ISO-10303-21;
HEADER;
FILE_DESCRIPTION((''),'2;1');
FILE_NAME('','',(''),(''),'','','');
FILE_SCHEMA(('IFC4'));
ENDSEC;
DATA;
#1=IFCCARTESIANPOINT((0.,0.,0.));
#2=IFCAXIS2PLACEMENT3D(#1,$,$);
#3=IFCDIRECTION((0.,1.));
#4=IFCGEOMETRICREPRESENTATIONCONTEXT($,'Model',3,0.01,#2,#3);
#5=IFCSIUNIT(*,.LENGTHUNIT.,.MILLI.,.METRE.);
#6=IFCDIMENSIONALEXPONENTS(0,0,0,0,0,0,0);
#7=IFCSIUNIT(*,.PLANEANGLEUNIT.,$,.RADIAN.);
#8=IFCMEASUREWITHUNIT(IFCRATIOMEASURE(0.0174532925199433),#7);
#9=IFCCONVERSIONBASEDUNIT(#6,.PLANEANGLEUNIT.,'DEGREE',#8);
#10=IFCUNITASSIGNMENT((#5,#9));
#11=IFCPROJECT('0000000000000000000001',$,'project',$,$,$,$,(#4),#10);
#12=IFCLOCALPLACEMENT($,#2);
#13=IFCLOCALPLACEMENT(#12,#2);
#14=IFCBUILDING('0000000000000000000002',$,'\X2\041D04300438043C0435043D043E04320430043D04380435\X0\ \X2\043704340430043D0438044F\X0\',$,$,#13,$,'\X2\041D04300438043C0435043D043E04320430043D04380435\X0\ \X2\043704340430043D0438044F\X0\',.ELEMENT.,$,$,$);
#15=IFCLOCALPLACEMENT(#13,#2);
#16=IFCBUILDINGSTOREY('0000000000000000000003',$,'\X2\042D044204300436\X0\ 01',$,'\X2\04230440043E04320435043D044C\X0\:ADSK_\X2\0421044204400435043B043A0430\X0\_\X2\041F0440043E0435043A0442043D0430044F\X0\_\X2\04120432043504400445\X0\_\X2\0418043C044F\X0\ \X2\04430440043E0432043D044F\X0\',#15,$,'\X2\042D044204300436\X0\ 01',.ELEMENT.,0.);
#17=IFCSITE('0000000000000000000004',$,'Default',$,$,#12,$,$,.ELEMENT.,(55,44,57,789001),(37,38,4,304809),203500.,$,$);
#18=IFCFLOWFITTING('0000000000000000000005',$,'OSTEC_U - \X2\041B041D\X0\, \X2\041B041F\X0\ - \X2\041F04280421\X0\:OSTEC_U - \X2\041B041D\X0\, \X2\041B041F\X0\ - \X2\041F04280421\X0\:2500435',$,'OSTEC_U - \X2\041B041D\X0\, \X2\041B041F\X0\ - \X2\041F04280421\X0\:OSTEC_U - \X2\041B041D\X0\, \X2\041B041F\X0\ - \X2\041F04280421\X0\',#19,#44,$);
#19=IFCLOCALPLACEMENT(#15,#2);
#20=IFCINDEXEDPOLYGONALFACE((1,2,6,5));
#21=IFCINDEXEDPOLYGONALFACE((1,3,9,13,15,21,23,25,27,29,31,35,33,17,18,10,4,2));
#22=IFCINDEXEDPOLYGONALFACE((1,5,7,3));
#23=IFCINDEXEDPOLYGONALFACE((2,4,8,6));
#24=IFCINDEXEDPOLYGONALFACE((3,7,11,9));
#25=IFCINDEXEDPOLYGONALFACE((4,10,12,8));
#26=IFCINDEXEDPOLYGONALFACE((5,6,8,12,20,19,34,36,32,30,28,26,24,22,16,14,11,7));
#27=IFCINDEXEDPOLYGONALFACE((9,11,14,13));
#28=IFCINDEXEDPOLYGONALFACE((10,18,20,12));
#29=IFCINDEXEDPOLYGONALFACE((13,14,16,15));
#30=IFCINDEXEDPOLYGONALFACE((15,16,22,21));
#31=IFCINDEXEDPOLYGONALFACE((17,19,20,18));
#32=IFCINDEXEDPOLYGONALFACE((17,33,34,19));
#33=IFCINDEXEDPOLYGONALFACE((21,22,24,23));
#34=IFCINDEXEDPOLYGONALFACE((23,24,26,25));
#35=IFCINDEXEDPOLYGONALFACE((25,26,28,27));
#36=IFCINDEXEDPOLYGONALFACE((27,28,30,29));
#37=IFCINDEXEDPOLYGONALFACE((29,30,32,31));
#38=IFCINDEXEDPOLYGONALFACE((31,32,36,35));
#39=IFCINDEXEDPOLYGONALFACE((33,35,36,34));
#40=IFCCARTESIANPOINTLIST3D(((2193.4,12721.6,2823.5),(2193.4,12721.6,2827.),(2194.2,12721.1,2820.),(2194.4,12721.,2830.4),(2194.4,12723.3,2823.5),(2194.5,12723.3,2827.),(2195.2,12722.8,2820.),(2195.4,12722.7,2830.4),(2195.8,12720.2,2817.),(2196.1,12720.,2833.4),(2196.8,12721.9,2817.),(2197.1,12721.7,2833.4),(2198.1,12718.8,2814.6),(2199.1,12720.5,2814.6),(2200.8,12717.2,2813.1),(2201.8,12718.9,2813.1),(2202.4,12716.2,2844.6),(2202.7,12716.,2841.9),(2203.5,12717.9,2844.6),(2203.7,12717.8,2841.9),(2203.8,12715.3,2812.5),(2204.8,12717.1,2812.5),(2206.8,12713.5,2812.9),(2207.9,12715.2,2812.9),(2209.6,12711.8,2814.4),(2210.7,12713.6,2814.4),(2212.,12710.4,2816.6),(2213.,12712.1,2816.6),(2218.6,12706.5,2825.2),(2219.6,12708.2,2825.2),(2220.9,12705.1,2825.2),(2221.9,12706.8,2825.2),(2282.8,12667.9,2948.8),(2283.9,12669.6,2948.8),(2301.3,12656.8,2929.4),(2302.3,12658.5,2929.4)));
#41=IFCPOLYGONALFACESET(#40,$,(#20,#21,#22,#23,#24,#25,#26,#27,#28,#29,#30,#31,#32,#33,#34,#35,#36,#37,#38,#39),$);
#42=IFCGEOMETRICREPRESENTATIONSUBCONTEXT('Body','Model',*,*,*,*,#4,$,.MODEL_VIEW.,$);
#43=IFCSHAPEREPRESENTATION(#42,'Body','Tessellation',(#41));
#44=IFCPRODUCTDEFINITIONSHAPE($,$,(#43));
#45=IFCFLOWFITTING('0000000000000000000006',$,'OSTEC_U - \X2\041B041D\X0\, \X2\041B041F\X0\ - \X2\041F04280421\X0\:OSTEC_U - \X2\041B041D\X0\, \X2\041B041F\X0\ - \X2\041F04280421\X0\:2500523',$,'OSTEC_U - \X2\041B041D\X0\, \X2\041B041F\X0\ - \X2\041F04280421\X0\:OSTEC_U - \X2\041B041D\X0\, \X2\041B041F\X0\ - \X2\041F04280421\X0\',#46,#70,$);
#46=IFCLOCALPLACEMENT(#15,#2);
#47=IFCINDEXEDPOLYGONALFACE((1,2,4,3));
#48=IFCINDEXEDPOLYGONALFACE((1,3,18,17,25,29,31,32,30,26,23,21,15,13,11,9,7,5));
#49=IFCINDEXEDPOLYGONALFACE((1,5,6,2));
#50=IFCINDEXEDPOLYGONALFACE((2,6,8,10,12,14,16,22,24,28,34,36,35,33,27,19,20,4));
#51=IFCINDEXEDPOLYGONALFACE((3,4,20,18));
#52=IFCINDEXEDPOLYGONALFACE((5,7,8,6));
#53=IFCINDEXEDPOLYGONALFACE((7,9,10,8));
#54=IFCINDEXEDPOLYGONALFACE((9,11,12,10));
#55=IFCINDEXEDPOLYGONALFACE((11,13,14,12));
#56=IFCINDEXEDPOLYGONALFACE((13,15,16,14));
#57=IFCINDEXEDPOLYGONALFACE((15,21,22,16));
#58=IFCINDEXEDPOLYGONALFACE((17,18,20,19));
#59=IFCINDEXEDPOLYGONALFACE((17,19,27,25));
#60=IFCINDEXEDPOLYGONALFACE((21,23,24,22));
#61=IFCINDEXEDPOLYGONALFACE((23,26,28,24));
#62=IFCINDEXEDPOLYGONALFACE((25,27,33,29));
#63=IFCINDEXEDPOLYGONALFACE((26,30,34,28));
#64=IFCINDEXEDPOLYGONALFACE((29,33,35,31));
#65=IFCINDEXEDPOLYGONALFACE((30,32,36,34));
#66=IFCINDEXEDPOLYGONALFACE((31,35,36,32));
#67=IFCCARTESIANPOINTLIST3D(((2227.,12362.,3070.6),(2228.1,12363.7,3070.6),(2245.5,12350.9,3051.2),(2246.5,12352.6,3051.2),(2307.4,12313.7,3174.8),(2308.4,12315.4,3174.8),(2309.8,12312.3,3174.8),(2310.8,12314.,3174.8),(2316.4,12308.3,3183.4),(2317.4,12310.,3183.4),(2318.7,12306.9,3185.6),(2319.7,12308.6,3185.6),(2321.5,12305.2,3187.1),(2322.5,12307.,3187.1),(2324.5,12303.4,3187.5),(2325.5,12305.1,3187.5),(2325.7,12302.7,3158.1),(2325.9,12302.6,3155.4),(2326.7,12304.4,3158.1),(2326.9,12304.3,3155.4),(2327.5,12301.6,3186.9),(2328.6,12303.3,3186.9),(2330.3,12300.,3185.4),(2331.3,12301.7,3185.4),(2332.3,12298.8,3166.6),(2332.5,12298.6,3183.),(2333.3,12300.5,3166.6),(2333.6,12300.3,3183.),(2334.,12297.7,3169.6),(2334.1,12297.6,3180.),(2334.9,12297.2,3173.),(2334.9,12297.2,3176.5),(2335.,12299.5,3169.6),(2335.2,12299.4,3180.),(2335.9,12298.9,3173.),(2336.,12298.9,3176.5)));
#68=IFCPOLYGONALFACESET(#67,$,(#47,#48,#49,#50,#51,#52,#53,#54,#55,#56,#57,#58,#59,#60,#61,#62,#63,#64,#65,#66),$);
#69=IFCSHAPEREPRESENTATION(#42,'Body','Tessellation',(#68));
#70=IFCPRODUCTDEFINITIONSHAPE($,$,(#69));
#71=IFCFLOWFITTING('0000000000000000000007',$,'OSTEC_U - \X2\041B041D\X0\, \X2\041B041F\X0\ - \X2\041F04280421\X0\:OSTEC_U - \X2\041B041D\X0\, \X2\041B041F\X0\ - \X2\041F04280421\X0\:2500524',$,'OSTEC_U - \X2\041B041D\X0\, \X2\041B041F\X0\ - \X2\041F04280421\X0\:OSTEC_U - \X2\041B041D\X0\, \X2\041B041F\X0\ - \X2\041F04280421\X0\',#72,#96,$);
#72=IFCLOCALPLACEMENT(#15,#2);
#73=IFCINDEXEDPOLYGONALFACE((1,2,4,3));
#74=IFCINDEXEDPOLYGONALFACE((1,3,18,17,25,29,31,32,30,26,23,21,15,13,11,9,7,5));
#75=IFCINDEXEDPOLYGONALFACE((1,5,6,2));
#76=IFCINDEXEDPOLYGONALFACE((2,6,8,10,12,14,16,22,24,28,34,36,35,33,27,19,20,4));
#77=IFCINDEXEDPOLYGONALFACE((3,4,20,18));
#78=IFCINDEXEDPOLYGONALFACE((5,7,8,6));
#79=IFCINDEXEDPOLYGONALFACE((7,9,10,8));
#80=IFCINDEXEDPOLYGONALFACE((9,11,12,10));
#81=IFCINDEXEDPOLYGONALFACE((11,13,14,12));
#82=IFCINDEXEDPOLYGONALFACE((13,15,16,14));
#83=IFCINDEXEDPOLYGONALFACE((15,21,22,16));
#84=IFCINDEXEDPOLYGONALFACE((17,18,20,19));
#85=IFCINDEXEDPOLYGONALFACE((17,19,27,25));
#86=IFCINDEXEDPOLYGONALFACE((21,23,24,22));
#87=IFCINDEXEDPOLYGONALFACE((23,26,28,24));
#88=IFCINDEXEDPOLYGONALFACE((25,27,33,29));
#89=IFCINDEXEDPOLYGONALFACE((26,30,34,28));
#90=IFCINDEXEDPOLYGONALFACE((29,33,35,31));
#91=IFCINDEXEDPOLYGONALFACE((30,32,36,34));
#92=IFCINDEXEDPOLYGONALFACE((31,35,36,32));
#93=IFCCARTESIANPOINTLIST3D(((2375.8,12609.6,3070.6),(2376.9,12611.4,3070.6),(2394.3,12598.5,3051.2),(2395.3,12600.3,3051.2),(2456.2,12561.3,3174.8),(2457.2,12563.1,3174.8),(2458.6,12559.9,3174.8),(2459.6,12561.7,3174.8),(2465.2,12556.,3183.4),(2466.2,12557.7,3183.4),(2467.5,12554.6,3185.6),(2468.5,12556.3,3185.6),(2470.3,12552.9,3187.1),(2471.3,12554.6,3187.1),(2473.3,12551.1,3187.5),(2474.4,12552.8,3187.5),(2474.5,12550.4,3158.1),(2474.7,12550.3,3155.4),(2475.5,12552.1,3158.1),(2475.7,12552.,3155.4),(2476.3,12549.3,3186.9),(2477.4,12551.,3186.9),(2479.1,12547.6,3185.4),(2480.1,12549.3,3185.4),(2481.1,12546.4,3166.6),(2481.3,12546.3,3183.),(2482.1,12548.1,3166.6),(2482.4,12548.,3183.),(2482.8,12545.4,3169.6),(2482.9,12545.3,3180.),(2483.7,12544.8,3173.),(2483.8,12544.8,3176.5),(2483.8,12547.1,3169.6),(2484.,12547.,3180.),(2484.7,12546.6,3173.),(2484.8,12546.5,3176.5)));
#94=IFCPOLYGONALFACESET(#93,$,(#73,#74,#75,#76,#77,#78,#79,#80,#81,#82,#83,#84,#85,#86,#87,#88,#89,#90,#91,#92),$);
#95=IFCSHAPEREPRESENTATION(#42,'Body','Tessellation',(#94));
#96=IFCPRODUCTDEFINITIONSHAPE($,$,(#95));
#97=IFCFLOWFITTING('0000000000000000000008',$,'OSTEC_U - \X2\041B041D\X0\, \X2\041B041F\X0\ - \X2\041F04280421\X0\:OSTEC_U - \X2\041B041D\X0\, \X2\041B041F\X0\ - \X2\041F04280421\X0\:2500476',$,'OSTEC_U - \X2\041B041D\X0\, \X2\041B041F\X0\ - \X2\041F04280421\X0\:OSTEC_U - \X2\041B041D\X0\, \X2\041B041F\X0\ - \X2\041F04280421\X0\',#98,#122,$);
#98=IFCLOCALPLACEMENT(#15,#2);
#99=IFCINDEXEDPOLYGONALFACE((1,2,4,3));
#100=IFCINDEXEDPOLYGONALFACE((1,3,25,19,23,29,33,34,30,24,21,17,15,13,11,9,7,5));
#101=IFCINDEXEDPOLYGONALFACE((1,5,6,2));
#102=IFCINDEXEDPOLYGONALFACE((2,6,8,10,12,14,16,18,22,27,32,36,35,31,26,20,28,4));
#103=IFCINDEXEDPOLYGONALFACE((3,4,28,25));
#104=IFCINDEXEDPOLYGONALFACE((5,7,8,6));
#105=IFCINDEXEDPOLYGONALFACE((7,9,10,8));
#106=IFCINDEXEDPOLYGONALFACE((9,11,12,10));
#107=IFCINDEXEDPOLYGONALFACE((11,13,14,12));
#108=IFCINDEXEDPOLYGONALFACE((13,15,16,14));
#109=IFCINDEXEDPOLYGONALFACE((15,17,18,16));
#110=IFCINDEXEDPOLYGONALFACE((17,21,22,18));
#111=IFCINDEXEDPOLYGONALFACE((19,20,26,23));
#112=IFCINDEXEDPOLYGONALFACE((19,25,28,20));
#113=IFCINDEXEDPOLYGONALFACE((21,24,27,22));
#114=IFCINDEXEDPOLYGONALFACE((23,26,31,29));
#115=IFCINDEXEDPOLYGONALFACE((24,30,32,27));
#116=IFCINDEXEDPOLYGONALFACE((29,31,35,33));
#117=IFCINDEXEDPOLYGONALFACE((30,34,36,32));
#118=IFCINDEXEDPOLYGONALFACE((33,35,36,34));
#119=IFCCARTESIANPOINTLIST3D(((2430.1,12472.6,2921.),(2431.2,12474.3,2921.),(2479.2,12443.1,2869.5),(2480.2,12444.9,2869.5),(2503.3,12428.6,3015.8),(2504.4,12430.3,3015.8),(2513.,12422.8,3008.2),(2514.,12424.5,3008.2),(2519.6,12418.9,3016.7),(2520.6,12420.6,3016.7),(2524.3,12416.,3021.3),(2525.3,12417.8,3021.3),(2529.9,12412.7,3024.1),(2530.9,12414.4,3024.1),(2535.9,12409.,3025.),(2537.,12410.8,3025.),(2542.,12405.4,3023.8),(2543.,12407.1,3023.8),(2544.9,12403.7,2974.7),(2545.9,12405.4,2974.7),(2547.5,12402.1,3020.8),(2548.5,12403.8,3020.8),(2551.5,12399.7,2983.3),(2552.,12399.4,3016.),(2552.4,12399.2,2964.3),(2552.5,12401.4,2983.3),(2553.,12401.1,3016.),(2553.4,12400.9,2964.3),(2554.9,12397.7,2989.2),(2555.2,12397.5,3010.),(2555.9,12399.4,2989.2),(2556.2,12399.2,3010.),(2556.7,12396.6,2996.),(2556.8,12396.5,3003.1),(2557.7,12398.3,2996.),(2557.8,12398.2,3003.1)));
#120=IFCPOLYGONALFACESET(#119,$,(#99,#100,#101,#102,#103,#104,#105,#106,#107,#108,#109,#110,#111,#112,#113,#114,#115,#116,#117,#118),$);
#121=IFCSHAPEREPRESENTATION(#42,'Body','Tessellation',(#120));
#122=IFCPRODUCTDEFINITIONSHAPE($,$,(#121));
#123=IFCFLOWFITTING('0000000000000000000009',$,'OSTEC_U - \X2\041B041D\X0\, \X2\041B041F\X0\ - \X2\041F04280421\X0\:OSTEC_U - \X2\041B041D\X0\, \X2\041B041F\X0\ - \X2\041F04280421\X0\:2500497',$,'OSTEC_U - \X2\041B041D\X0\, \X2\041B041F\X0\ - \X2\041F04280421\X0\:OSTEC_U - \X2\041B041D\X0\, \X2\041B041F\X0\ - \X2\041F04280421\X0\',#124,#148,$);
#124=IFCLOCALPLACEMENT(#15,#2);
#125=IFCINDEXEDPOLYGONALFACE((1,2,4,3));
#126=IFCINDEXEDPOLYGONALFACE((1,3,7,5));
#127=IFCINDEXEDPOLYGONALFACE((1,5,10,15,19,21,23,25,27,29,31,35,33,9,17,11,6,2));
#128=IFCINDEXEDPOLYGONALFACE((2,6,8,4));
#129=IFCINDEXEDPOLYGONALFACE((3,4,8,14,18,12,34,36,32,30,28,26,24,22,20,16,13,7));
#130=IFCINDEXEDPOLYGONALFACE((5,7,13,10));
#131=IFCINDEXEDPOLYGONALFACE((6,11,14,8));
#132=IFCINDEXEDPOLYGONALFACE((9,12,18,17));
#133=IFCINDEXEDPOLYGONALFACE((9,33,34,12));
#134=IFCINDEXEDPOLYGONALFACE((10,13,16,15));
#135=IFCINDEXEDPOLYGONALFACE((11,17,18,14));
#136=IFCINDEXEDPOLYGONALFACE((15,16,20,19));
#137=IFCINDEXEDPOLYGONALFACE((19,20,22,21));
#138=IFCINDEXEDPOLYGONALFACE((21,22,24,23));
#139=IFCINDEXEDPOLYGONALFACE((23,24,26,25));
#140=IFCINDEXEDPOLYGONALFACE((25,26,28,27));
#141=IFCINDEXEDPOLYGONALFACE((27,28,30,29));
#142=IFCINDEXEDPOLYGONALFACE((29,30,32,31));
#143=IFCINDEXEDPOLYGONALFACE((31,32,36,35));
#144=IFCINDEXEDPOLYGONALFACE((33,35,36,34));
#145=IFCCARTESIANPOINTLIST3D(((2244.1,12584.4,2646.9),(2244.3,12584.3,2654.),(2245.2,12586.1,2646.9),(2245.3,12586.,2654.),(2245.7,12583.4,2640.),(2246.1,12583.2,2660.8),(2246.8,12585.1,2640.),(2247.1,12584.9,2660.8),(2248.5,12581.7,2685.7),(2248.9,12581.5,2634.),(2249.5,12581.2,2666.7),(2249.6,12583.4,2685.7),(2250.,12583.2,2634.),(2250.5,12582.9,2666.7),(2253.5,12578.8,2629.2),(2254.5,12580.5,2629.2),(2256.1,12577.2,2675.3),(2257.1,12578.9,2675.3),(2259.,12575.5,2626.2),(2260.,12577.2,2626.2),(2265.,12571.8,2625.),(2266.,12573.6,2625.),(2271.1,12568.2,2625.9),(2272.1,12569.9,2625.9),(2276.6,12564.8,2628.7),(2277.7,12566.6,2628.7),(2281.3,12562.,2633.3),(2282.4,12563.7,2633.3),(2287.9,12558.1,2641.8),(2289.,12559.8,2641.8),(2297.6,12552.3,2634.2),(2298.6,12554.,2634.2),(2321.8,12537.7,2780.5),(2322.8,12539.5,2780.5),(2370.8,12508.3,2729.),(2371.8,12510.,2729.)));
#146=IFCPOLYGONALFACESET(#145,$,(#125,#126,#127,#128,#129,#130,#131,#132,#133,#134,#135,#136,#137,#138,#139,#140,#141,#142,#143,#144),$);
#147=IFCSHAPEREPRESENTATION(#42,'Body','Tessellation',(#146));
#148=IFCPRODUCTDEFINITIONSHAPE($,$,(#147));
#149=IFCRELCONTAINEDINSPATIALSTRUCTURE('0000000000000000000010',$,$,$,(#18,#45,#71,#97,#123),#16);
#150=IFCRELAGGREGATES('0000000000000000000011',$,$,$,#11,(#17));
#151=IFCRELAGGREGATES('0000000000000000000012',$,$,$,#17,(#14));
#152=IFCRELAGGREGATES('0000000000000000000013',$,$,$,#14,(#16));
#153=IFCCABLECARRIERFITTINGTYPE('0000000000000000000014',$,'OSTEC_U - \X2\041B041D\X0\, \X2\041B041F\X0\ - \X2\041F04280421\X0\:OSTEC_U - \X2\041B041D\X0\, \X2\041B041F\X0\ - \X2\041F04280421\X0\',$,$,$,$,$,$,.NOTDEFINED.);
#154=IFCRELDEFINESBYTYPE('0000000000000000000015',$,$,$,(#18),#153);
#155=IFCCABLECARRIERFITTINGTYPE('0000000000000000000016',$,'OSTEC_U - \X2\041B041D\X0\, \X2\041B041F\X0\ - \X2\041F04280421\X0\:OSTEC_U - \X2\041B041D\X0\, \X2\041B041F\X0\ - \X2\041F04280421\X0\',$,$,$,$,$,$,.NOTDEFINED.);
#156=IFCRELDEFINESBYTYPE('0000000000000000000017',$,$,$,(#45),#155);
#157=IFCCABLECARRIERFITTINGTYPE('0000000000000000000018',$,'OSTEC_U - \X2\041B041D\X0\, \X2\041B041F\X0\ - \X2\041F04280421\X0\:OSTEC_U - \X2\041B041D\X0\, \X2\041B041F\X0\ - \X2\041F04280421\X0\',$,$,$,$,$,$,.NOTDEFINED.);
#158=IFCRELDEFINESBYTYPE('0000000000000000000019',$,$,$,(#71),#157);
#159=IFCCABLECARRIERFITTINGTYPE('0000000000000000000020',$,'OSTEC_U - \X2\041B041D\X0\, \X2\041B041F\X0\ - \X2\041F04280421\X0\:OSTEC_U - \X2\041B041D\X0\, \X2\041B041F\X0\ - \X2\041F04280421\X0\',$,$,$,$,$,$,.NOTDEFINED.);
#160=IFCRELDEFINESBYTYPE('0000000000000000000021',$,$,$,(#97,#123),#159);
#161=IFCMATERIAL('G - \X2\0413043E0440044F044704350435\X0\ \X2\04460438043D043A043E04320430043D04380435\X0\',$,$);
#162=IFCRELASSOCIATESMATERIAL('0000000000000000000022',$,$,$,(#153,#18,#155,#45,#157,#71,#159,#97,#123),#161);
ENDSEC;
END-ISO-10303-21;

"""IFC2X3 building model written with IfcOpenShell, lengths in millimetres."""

from ifc_helpers import new_model, entity, si_unit, converted_unit, direction, frame, frame_2d, origin, place, context, subcontext, project, spatial, polyline, circle_curve, parameter, trimmed, segment, composite_curve, outline, extrude, source, transform, mapped, material, type_object, type_shapes, element, save


model = new_model("IFC2X3")

# Units and contexts
model_context = context("Model", 3, precision=0.01, world=origin(), true_north=direction((0.0, 1.0)))
body_context = subcontext(model_context, "Body", "Model", "MODEL_VIEW")
ifc_project = project(units=[si_unit("LENGTHUNIT", "METRE", prefix="MILLI"), converted_unit("PLANEANGLEUNIT", "DEGREE", entity("IfcRatioMeasure", 0.0174532925199433), si_unit("PLANEANGLEUNIT", "RADIAN"), dimensions=[0, 0, 0, 0, 0, 0, 0])], contexts=[model_context])

# Site, building, storey
site_placement = place(None, frame((0.0, 0.0, 0.0)))
site = spatial("IfcSite", under=ifc_project, at=site_placement, Name="Default", CompositionType="ELEMENT", RefLatitude=(55, 44, 57, 789001), RefLongitude=(37, 38, 4, 304809), RefElevation=203500.0)
building_placement = place(site_placement, origin())
building = spatial("IfcBuilding", under=site, at=building_placement, Name="Наименование здания", LongName="Наименование здания", CompositionType="ELEMENT")
storey_placement = place(building_placement, origin())
storey = spatial("IfcBuildingStorey", under=building, at=storey_placement, Name="Этаж 01", ObjectType="Уровень:ADSK_Стрелка_Проектная_Вверх_Имя уровня", LongName="Этаж 01", CompositionType="ELEMENT", Elevation=0.0)

# Flow fittings
ifc_material_1 = material(Name="G - Горячее цинкование")
cable_carrier_fitting_type_1 = type_object("IfcCableCarrierFittingType", Name="OSTEC_U - ЛН, ЛП - ПШС:OSTEC_U - ЛН, ЛП - ПШС", PredefinedType="NOTDEFINED", material=ifc_material_1)
shared_shape_1 = source(origin(), body_context, "Body", "SweptSolid", [
    extrude(outline(composite_curve([segment(trimmed(circle_curve(frame_2d((-44.6, 0.0), x_axis=(1.0, 0.0)), 12.5), [parameter(90.0)], [parameter(270.0)], True, "PARAMETER"), True, "CONTINUOUS"), segment(polyline([(-44.6, -12.5), (-33.1, -12.5)]), True, "CONTINUOUS"), segment(polyline([(-33.1, -12.5), (-31.2, -14.5)]), True, "CONTINUOUS"), segment(polyline([(-31.2, -14.5), (108.9, -14.5)]), True, "CONTINUOUS"), segment(polyline([(108.9, -14.5), (108.9, 14.5)]), True, "CONTINUOUS"), segment(polyline([(108.9, 14.5), (-31.2, 14.5)]), True, "CONTINUOUS"), segment(polyline([(-31.2, 14.5), (-33.1, 12.5)]), True, "CONTINUOUS"), segment(polyline([(-33.1, 12.5), (-44.6, 12.5)]), True, "CONTINUOUS")], self_intersect=False)), frame((44.6, 0.0, 0.0)), (0.0, 0.0, 1.0), 2.0),
])
type_shapes(cable_carrier_fitting_type_1, [shared_shape_1])
for number, where, z_axis, x_axis, name in (
    (1, (2204.0, 12715.2, 2825.0), (0.515038, 0.857167, 0.0), (0.573557, -0.344628, 0.743145), "OSTEC_U - ЛН, ЛП - ПШС:OSTEC_U - ЛН, ЛП - ПШС:2500435"),
):
    element("IfcFlowFitting", number, at=place(storey_placement, frame(where, z_axis=z_axis, x_axis=x_axis)), inside=storey, type_object=cable_carrier_fitting_type_1, material=ifc_material_1, Name=name, ObjectType="OSTEC_U - ЛН, ЛП - ПШС:OSTEC_U - ЛН, ЛП - ПШС", context=body_context, shape_type="MappedRepresentation", body=[
        mapped(shared_shape_1, transform((0.0, 0.0, 0.0), scale=1.0)),
    ])
cable_carrier_fitting_type_2 = type_object("IfcCableCarrierFittingType", Name="OSTEC_U - ЛН, ЛП - ПШС:OSTEC_U - ЛН, ЛП - ПШС", PredefinedType="NOTDEFINED", material=ifc_material_1)
shared_shape_2 = source(origin(), body_context, "Body", "SweptSolid", [
    extrude(outline(composite_curve([segment(trimmed(circle_curve(frame_2d((-44.6, 0.0), x_axis=(1.0, 0.0)), 12.5), [parameter(90.0)], [parameter(270.0)], True, "PARAMETER"), True, "CONTINUOUS"), segment(polyline([(-44.6, -12.5), (-33.1, -12.5)]), True, "CONTINUOUS"), segment(polyline([(-33.1, -12.5), (-31.2, -14.5)]), True, "CONTINUOUS"), segment(polyline([(-31.2, -14.5), (108.9, -14.5)]), True, "CONTINUOUS"), segment(polyline([(108.9, -14.5), (108.9, 14.5)]), True, "CONTINUOUS"), segment(polyline([(108.9, 14.5), (-31.2, 14.5)]), True, "CONTINUOUS"), segment(polyline([(-31.2, 14.5), (-33.1, 12.5)]), True, "CONTINUOUS"), segment(polyline([(-33.1, 12.5), (-44.6, 12.5)]), True, "CONTINUOUS")], self_intersect=False)), frame((44.6, 0.0, 0.0), z_axis=(0.0, 0.0, -1.0), x_axis=(1.0, 0.0, 0.0)), (0.0, 0.0, -1.0), 2.0),
])
type_shapes(cable_carrier_fitting_type_2, [shared_shape_2])
for number, where, z_axis, x_axis, name in (
    (2, (2325.3, 12305.3, 3175.0), (-0.515038, -0.857167, 0.0), (-0.573557, 0.344628, -0.743145), "OSTEC_U - ЛН, ЛП - ПШС:OSTEC_U - ЛН, ЛП - ПШС:2500523"),
):
    element("IfcFlowFitting", number, at=place(storey_placement, frame(where, z_axis=z_axis, x_axis=x_axis)), inside=storey, type_object=cable_carrier_fitting_type_2, material=ifc_material_1, Name=name, ObjectType="OSTEC_U - ЛН, ЛП - ПШС:OSTEC_U - ЛН, ЛП - ПШС", context=body_context, shape_type="MappedRepresentation", body=[
        mapped(shared_shape_2, transform((0.0, 0.0, 0.0), scale=1.0)),
    ])
cable_carrier_fitting_type_3 = type_object("IfcCableCarrierFittingType", Name="OSTEC_U - ЛН, ЛП - ПШС:OSTEC_U - ЛН, ЛП - ПШС", PredefinedType="NOTDEFINED", material=ifc_material_1)
shared_shape_3 = source(origin(), body_context, "Body", "SweptSolid", [
    extrude(outline(composite_curve([segment(trimmed(circle_curve(frame_2d((-44.6, 0.0), x_axis=(1.0, 0.0)), 12.5), [parameter(90.0)], [parameter(270.0)], True, "PARAMETER"), True, "CONTINUOUS"), segment(polyline([(-44.6, -12.5), (-33.1, -12.5)]), True, "CONTINUOUS"), segment(polyline([(-33.1, -12.5), (-31.2, -14.5)]), True, "CONTINUOUS"), segment(polyline([(-31.2, -14.5), (108.9, -14.5)]), True, "CONTINUOUS"), segment(polyline([(108.9, -14.5), (108.9, 14.5)]), True, "CONTINUOUS"), segment(polyline([(108.9, 14.5), (-31.2, 14.5)]), True, "CONTINUOUS"), segment(polyline([(-31.2, 14.5), (-33.1, 12.5)]), True, "CONTINUOUS"), segment(polyline([(-33.1, 12.5), (-44.6, 12.5)]), True, "CONTINUOUS")], self_intersect=False)), frame((44.6, 0.0, 0.0)), (0.0, 0.0, 1.0), 2.0),
])
type_shapes(cable_carrier_fitting_type_3, [shared_shape_3])
for number, where, z_axis, x_axis, name in (
    (3, (2473.1, 12551.2, 3175.0), (0.515038, 0.857167, 0.0), (-0.573557, 0.344628, -0.743145), "OSTEC_U - ЛН, ЛП - ПШС:OSTEC_U - ЛН, ЛП - ПШС:2500524"),
):
    element("IfcFlowFitting", number, at=place(storey_placement, frame(where, z_axis=z_axis, x_axis=x_axis)), inside=storey, type_object=cable_carrier_fitting_type_3, material=ifc_material_1, Name=name, ObjectType="OSTEC_U - ЛН, ЛП - ПШС:OSTEC_U - ЛН, ЛП - ПШС", context=body_context, shape_type="MappedRepresentation", body=[
        mapped(shared_shape_3, transform((0.0, 0.0, 0.0), scale=1.0)),
    ])
cable_carrier_fitting_type_4 = type_object("IfcCableCarrierFittingType", Name="OSTEC_U - ЛН, ЛП - ПШС:OSTEC_U - ЛН, ЛП - ПШС", PredefinedType="NOTDEFINED", material=ifc_material_1)
shared_shape_4 = source(origin(), body_context, "Body", "SweptSolid", [
    extrude(outline(composite_curve([segment(trimmed(circle_curve(frame_2d((-41.5, 0.0), x_axis=(1.0, 0.0)), 25.0), [parameter(90.0)], [parameter(270.0)], True, "PARAMETER"), True, "CONTINUOUS"), segment(polyline([(-41.5, -25.0), (-30.0, -25.0)]), True, "CONTINUOUS"), segment(polyline([(-30.0, -25.0), (-28.1, -38.5)]), True, "CONTINUOUS"), segment(polyline([(-28.1, -38.5), (99.5, -38.5)]), True, "CONTINUOUS"), segment(polyline([(99.5, -38.5), (99.5, 38.5)]), True, "CONTINUOUS"), segment(polyline([(99.5, 38.5), (-28.1, 38.5)]), True, "CONTINUOUS"), segment(polyline([(-28.1, 38.5), (-30.0, 25.0)]), True, "CONTINUOUS"), segment(polyline([(-30.0, 25.0), (-41.5, 25.0)]), True, "CONTINUOUS")], self_intersect=False)), frame((41.5, 0.0, 0.0), z_axis=(0.0, 0.0, -1.0), x_axis=(1.0, 0.0, 0.0)), (0.0, 0.0, -1.0), 2.0),
])
type_shapes(cable_carrier_fitting_type_4, [shared_shape_4])
for number, where, z_axis, x_axis, name in (
    (4, (2536.6, 12411.0, 3000.0), (-0.515038, -0.857167, 0.0), (-0.573557, 0.344628, -0.743145), "OSTEC_U - ЛН, ЛП - ПШС:OSTEC_U - ЛН, ЛП - ПШС:2500476"),
    (5, (2266.4, 12573.3, 2650.0), (-0.515038, -0.857167, 0.0), (0.573557, -0.344628, 0.743145), "OSTEC_U - ЛН, ЛП - ПШС:OSTEC_U - ЛН, ЛП - ПШС:2500497"),
):
    element("IfcFlowFitting", number, at=place(storey_placement, frame(where, z_axis=z_axis, x_axis=x_axis)), inside=storey, type_object=cable_carrier_fitting_type_4, material=ifc_material_1, Name=name, ObjectType="OSTEC_U - ЛН, ЛП - ПШС:OSTEC_U - ЛН, ЛП - ПШС", context=body_context, shape_type="MappedRepresentation", body=[
        mapped(shared_shape_4, transform((0.0, 0.0, 0.0), scale=1.0)),
    ])

save(model, "model.ifc")
